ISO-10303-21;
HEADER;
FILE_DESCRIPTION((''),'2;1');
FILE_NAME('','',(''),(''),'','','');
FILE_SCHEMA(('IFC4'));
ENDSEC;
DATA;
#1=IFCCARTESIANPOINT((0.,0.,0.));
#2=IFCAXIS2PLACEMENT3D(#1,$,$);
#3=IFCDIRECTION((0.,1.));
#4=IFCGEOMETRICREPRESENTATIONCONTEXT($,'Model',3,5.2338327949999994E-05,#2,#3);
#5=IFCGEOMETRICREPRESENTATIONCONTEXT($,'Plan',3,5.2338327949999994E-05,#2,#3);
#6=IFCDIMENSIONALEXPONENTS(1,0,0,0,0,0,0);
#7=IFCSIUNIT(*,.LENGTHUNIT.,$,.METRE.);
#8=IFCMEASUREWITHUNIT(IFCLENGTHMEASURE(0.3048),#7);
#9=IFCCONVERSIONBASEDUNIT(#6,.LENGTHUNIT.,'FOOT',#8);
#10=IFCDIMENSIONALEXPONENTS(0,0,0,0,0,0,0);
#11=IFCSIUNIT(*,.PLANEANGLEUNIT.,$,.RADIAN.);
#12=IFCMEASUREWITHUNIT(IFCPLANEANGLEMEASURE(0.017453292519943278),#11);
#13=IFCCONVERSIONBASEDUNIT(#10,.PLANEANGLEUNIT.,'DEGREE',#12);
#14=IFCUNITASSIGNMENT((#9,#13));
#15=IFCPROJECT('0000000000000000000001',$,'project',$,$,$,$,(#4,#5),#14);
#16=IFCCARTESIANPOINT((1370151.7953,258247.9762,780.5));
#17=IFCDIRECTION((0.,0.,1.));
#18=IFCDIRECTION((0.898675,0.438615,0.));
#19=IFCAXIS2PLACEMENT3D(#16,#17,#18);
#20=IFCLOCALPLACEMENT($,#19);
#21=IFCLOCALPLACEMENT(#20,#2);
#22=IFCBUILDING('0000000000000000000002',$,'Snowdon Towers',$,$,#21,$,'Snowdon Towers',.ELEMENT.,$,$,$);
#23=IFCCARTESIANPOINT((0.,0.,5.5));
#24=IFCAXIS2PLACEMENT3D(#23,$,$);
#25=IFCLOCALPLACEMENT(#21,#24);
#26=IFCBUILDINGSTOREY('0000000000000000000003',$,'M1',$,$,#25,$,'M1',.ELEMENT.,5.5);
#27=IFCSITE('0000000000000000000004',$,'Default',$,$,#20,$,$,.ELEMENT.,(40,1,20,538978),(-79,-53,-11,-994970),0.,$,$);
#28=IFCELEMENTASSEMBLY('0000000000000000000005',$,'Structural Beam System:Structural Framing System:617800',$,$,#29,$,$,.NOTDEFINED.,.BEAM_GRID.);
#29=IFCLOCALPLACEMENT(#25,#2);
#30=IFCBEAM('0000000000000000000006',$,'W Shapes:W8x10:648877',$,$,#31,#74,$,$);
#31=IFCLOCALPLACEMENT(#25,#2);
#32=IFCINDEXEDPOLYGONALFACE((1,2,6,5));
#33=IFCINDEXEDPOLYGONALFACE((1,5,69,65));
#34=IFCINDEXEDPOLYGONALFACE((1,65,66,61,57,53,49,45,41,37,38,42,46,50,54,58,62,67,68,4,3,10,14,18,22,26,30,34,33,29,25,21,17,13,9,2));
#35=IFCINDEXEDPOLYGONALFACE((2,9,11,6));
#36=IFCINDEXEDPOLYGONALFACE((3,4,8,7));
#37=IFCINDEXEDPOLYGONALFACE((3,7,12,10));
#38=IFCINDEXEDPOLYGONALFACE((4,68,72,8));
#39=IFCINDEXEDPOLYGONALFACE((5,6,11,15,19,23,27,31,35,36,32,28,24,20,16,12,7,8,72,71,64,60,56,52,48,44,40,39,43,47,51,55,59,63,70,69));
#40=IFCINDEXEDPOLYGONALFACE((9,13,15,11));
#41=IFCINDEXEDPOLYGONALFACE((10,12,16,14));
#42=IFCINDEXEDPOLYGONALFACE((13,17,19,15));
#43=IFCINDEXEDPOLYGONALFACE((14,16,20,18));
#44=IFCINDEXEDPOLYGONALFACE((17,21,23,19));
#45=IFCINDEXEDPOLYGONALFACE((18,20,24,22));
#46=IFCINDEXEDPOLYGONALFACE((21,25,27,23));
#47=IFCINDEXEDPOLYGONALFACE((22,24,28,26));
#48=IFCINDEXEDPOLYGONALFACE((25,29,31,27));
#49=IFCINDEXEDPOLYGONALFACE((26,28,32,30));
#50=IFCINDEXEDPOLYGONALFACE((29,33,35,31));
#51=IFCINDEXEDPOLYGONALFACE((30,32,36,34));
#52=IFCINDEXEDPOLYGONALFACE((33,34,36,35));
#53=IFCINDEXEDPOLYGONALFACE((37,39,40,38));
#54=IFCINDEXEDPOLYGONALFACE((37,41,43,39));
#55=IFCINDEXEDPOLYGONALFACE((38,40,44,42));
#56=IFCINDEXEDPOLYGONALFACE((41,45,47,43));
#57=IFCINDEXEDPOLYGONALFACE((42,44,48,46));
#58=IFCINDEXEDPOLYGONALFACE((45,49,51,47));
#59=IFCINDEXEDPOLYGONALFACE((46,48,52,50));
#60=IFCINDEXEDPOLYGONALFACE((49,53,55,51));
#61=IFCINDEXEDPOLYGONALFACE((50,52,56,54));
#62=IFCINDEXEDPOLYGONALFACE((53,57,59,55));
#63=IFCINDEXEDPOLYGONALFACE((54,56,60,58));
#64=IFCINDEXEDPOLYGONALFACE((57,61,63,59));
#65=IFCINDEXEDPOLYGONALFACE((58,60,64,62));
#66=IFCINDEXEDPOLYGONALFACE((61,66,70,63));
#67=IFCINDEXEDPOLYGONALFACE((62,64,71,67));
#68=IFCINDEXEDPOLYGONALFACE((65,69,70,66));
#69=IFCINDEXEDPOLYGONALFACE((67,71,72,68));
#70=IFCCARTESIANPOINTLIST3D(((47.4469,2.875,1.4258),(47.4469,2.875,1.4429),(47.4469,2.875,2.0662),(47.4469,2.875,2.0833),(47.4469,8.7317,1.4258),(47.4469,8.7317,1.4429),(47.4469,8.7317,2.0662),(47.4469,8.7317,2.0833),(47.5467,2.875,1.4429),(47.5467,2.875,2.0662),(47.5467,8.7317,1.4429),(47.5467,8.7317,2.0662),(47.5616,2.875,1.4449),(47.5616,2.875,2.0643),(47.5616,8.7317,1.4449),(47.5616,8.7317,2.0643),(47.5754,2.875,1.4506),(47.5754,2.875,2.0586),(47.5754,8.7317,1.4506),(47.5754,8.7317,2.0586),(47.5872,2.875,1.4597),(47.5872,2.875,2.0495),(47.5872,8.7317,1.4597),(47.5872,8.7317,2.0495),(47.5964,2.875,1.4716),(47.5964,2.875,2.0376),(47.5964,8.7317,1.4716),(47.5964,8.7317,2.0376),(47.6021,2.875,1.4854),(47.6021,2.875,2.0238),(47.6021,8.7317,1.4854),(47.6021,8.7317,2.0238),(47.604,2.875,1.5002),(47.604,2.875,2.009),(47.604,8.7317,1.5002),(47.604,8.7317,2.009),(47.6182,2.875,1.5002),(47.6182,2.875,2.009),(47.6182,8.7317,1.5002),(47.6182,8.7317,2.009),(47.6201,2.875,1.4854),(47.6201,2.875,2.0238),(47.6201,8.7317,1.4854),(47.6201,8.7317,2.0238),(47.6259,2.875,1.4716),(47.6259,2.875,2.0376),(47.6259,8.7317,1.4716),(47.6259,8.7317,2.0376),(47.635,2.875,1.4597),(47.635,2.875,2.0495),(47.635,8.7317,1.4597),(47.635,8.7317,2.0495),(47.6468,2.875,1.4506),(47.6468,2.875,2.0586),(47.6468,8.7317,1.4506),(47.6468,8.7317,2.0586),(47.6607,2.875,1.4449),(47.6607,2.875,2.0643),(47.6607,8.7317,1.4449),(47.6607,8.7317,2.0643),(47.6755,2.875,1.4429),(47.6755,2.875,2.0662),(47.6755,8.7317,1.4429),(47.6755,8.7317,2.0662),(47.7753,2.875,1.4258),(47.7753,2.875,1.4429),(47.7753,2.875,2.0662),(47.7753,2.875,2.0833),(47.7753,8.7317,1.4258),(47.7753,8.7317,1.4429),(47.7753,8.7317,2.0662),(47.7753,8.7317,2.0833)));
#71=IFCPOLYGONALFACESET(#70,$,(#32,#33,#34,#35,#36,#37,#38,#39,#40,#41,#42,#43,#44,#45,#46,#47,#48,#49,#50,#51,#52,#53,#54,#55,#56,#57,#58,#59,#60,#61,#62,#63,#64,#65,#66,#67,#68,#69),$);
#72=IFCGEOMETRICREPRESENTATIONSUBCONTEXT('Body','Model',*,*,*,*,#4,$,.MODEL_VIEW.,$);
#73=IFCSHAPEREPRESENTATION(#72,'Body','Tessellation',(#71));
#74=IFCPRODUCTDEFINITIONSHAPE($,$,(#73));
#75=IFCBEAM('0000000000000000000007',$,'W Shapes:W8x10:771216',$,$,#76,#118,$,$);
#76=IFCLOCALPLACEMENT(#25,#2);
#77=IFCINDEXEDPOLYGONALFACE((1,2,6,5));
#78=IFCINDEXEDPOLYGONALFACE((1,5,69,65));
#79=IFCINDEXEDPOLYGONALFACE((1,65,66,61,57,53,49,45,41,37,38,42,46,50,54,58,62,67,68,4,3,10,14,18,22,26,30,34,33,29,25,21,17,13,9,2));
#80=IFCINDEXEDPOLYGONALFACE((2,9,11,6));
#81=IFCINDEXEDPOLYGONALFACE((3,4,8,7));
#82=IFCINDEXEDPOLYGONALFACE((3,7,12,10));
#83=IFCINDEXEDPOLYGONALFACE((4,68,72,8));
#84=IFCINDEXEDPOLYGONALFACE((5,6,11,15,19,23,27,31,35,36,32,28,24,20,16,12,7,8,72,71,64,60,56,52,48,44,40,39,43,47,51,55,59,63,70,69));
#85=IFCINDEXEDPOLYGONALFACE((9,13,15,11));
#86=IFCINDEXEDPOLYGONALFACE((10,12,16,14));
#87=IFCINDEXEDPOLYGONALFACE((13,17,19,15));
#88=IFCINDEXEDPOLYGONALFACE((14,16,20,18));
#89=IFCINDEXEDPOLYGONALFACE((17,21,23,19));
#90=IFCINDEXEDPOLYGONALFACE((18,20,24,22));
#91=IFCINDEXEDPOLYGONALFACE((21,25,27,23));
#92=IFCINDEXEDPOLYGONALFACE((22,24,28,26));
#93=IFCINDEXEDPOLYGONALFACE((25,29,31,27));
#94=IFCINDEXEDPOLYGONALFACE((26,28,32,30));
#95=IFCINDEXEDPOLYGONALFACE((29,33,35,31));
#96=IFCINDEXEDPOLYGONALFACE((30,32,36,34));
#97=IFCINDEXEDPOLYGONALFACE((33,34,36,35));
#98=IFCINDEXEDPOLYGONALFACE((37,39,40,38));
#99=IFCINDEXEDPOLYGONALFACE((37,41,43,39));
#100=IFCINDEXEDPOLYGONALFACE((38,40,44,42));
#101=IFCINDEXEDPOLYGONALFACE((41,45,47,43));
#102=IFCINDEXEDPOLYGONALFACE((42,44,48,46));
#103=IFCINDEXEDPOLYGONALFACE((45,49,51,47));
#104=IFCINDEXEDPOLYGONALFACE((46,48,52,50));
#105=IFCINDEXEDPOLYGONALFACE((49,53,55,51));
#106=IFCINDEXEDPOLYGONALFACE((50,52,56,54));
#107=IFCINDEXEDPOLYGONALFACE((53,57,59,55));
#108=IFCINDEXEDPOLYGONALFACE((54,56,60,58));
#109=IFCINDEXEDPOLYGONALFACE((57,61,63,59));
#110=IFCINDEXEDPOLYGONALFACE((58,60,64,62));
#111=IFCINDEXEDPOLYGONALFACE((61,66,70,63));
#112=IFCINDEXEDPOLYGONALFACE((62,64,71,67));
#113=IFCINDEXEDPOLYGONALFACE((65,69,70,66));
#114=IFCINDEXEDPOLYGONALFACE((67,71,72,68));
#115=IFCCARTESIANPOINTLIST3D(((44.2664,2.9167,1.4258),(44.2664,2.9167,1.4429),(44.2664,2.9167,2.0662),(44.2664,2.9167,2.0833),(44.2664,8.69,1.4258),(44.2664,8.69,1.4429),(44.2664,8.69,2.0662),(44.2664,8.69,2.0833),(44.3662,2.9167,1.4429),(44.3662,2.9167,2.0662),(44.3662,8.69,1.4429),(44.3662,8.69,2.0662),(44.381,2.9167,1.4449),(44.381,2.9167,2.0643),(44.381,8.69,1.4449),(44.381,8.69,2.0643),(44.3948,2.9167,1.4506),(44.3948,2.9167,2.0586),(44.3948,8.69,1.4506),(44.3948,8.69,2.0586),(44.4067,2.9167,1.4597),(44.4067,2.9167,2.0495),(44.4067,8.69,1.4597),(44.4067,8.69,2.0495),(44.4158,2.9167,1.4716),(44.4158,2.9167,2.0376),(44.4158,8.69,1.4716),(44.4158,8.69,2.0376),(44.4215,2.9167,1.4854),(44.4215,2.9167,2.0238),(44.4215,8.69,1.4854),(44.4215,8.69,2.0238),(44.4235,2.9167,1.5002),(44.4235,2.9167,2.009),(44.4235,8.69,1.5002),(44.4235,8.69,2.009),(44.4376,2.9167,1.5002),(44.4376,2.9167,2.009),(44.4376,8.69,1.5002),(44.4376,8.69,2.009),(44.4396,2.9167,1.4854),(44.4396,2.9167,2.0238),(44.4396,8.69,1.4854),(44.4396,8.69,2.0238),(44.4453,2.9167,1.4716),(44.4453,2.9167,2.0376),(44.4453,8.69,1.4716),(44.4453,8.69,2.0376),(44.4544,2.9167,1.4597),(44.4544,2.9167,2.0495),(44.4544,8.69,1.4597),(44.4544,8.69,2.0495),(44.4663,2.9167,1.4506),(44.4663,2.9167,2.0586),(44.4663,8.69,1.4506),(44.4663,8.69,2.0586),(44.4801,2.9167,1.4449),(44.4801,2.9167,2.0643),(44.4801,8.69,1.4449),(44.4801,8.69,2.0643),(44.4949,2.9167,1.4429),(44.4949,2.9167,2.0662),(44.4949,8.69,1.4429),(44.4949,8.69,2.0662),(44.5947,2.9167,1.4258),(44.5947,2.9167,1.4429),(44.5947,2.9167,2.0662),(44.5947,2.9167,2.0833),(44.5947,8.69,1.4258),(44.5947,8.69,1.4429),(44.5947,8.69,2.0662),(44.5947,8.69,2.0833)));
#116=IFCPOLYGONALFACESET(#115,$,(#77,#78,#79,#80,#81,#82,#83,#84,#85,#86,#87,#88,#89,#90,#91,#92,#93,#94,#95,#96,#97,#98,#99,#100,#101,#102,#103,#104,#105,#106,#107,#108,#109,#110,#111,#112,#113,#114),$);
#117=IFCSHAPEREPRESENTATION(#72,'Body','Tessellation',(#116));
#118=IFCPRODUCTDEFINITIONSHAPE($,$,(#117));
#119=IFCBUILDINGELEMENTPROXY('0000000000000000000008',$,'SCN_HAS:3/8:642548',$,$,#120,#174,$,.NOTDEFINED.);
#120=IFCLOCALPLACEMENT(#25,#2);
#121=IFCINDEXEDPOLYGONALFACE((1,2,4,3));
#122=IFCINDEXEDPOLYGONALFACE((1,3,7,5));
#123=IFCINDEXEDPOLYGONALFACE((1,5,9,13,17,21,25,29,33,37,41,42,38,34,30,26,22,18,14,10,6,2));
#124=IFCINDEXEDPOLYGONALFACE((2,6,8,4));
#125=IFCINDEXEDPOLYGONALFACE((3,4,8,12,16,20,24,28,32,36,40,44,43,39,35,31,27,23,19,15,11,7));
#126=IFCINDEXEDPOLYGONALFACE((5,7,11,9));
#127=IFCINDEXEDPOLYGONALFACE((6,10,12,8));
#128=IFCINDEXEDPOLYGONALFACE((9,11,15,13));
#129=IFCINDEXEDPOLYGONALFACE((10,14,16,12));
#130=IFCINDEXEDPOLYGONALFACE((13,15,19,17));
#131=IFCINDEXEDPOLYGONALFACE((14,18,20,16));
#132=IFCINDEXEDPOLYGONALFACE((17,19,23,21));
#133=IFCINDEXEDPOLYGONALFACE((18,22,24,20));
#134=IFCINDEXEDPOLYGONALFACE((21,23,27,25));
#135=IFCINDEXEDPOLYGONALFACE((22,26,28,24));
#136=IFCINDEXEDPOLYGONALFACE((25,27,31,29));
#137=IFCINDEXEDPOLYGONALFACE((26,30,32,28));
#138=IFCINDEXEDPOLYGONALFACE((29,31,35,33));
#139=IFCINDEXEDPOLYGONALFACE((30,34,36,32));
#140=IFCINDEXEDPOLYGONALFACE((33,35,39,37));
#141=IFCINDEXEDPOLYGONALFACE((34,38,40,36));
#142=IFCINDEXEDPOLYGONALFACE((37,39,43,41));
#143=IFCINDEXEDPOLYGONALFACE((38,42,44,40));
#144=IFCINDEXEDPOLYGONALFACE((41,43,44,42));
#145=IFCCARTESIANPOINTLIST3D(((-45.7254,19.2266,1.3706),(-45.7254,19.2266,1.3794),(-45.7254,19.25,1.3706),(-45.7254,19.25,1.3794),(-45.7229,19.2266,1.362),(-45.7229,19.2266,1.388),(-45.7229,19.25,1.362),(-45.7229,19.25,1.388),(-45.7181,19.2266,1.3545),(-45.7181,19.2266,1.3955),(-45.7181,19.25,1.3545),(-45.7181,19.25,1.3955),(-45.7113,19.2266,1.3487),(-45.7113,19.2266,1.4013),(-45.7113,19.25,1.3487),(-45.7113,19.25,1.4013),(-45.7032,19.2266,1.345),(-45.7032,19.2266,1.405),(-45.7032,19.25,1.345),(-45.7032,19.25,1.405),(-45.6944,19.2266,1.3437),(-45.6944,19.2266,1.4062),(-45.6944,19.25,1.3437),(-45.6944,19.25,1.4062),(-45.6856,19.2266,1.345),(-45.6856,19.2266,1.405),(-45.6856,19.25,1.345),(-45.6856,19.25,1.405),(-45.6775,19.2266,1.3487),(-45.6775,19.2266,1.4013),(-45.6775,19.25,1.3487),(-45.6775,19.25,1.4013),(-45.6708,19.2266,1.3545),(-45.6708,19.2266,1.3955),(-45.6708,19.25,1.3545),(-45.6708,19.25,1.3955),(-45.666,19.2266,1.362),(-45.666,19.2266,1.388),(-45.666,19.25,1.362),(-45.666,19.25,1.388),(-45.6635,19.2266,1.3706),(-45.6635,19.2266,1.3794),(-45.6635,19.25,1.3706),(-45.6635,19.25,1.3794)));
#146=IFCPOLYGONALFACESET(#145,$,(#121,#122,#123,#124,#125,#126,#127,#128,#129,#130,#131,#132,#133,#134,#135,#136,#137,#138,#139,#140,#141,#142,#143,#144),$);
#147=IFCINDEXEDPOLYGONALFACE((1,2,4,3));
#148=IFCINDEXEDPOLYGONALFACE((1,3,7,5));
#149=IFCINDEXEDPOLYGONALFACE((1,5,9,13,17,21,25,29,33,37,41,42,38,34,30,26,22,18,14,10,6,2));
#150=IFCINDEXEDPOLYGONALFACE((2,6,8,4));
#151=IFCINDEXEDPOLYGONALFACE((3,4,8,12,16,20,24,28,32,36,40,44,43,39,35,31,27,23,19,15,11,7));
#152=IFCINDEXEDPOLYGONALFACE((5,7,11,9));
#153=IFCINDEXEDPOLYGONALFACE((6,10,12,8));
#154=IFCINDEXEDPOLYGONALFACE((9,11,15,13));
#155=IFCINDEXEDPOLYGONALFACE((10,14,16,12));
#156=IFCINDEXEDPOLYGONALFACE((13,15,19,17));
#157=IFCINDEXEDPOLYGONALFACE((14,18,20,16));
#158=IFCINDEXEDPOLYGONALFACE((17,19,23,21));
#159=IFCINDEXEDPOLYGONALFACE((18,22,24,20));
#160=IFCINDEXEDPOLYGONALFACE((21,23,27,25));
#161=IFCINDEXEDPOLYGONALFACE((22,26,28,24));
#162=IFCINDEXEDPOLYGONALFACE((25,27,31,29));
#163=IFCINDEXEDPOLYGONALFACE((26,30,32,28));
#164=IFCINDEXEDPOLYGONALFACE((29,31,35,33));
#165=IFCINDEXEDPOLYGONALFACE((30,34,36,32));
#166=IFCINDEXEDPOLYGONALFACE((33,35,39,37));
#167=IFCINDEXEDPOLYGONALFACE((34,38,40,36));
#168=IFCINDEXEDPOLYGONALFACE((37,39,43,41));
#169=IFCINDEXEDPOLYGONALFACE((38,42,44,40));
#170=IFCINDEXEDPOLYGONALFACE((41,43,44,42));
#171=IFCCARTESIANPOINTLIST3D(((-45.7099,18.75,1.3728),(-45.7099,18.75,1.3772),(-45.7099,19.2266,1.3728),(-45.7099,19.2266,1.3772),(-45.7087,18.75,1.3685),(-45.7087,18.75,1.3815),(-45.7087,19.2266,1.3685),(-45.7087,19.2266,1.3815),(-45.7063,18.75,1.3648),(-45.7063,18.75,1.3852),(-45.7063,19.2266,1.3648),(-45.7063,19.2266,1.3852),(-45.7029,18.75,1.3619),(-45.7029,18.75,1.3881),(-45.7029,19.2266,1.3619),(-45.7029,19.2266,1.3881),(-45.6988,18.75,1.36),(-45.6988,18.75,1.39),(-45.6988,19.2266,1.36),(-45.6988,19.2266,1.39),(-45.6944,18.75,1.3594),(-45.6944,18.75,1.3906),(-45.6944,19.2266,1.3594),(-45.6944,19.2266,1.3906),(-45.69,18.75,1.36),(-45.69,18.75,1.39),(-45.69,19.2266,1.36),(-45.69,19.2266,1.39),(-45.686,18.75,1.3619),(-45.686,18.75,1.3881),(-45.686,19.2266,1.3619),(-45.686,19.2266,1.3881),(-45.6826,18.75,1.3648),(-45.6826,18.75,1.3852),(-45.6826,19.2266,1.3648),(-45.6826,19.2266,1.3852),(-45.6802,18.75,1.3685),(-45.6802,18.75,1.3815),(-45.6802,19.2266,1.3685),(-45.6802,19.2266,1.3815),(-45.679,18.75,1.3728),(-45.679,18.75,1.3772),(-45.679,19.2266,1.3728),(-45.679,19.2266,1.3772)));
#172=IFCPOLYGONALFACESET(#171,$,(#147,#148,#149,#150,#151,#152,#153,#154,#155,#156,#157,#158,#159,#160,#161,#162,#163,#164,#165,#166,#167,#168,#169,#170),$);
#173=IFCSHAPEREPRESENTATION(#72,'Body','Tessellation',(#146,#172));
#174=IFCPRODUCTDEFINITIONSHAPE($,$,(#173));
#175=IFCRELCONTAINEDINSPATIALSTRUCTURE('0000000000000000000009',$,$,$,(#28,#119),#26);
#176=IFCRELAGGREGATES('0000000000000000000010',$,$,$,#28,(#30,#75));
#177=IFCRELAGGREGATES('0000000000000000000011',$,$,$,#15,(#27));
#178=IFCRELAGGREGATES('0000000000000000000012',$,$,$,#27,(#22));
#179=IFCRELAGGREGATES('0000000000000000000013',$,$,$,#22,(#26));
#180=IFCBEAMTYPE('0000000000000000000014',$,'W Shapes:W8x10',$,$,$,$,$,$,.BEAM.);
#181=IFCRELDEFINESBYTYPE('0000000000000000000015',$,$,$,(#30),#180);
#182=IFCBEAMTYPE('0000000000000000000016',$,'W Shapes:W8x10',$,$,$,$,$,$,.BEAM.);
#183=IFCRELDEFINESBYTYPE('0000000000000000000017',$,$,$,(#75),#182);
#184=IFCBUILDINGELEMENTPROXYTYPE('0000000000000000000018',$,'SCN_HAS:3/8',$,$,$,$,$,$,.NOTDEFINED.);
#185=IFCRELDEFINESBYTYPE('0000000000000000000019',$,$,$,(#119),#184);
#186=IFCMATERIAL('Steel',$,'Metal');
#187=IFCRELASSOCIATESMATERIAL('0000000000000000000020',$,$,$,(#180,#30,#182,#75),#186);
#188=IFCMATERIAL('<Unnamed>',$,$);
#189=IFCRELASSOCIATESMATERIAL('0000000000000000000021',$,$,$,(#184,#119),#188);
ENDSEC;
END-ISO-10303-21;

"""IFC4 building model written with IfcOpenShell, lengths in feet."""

from ifc_helpers import new_model, entity, si_unit, converted_unit, direction, frame, origin, place, context, subcontext, project, spatial, line, arc, indexed_curve, outline, extrude, source, transform, mapped, material, type_object, type_shapes, element, aggregate, save


model = new_model("IFC4")

# Units and contexts
model_context = context("Model", 3, precision=5.2338327949999994e-05, world=origin(), true_north=direction((0.0, 1.0)))
plan_context = context("Plan", 3, precision=5.2338327949999994e-05, world=origin(), true_north=direction((0.0, 1.0)))
body_context = subcontext(model_context, "Body", "Model", "MODEL_VIEW")
ifc_project = project(units=[converted_unit("LENGTHUNIT", "FOOT", entity("IfcLengthMeasure", 0.3048), si_unit("LENGTHUNIT", "METRE"), dimensions=[1, 0, 0, 0, 0, 0, 0]), converted_unit("PLANEANGLEUNIT", "DEGREE", entity("IfcPlaneAngleMeasure", 0.017453292519943278), si_unit("PLANEANGLEUNIT", "RADIAN"), dimensions=[0, 0, 0, 0, 0, 0, 0])], contexts=[model_context, plan_context])

# Site, building, storey
site_placement = place(None, frame((1370151.7953, 258247.9762, 780.5), z_axis=(0.0, 0.0, 1.0), x_axis=(0.898675, 0.438615, 0.0)))
site = spatial("IfcSite", under=ifc_project, at=site_placement, Name="Default", CompositionType="ELEMENT", RefLatitude=(40, 1, 20, 538978), RefLongitude=(-79, -53, -11, -994970), RefElevation=0.0)
building_placement = place(site_placement, origin())
building = spatial("IfcBuilding", under=site, at=building_placement, Name="Snowdon Towers", LongName="Snowdon Towers", CompositionType="ELEMENT")
storey_placement = place(building_placement, frame((0.0, 0.0, 5.5)))
storey = spatial("IfcBuildingStorey", under=building, at=storey_placement, Name="M1", LongName="M1", CompositionType="ELEMENT", Elevation=5.5)

# Shared definitions
ifc_material_1 = material(Name="Steel", Category="Metal")

# Element assembly, beams
assembly_placement = place(storey_placement, origin())
assembly = element("IfcElementAssembly", 1, at=assembly_placement, inside=storey, Name="Structural Beam System:Structural Framing System:617800", AssemblyPlace="NOTDEFINED", PredefinedType="BEAM_GRID")
beam_type_1 = type_object("IfcBeamType", Name="W Shapes:W8x10", PredefinedType="BEAM", material=ifc_material_1)
shared_shape_1 = source(origin(), body_context, "Body", "SweptSolid", [
    extrude(outline(indexed_curve([(-0.3287, -0.1642), (-0.3117, -0.1642), (-0.3117, -0.0644), (-0.2949, -0.0239), (-0.2544, -0.0071), (0.2544, -0.0071), (0.2949, -0.0239), (0.3117, -0.0644), (0.3117, -0.1642), (0.3288, -0.1642), (0.3288, 0.1642), (0.3117, 0.1642), (0.3117, 0.0644), (0.2949, 0.0239), (0.2544, 0.0071), (-0.2544, 0.0071), (-0.2949, 0.0239), (-0.3117, 0.0644), (-0.3117, 0.1642), (-0.3287, 0.1642)], segments=[line(1, 2, 3), arc(3, 4, 5), line(5, 6), arc(6, 7, 8), line(8, 9, 10, 11, 12, 13), arc(13, 14, 15), line(15, 16), arc(16, 17, 18), line(18, 19, 20, 1)], self_intersect=False)), frame((-3.0962, 0.0, 0.0), z_axis=(1.0, 0.0, 0.0), x_axis=(0.0, 0.0, -1.0)), (0.0, 0.0, 1.0), 5.8567),
])
type_shapes(beam_type_1, [shared_shape_1])
beam_1_placement = place(assembly_placement, frame((47.6111, 5.6354, 1.7546), z_axis=(0.0, 0.0, 1.0), x_axis=(0.0, -1.0, 0.0)))
beam_1 = element("IfcBeam", 2, at=beam_1_placement, type_object=beam_type_1, material=ifc_material_1, Name="W Shapes:W8x10:648877", context=body_context, shape_type="MappedRepresentation", body=[
    mapped(shared_shape_1, transform((0.0, 0.0, 0.0), scale=1.0)),
])
beam_type_2 = type_object("IfcBeamType", Name="W Shapes:W8x10", PredefinedType="BEAM", material=ifc_material_1)
shared_shape_2 = source(origin(), body_context, "Body", "SweptSolid", [
    extrude(outline(indexed_curve([(-0.3287, -0.1642), (-0.3117, -0.1642), (-0.3117, -0.0644), (-0.2949, -0.0239), (-0.2544, -0.0071), (0.2544, -0.0071), (0.2949, -0.0239), (0.3117, -0.0644), (0.3117, -0.1642), (0.3288, -0.1642), (0.3288, 0.1642), (0.3117, 0.1642), (0.3117, 0.0644), (0.2949, 0.0239), (0.2544, 0.0071), (-0.2544, 0.0071), (-0.2949, 0.0239), (-0.3117, 0.0644), (-0.3117, 0.1642), (-0.3287, 0.1642)], segments=[line(1, 2, 3), arc(3, 4, 5), line(5, 6), arc(6, 7, 8), line(8, 9, 10, 11, 12, 13), arc(13, 14, 15), line(15, 16), arc(16, 17, 18), line(18, 19, 20, 1)], self_intersect=False)), frame((-3.0546, 0.0, 0.0), z_axis=(1.0, 0.0, 0.0), x_axis=(0.0, 0.0, -1.0)), (0.0, 0.0, 1.0), 5.7733),
])
type_shapes(beam_type_2, [shared_shape_2])
beam_2_placement = place(assembly_placement, frame((44.4306, 5.6354, 1.7546), z_axis=(0.0, 0.0, 1.0), x_axis=(0.0, -1.0, 0.0)))
beam_2 = element("IfcBeam", 3, at=beam_2_placement, type_object=beam_type_2, material=ifc_material_1, Name="W Shapes:W8x10:771216", context=body_context, shape_type="MappedRepresentation", body=[
    mapped(shared_shape_2, transform((0.0, 0.0, 0.0), scale=1.0)),
])
aggregate(assembly, [beam_1, beam_2])

# Building element proxy
ifc_material_2 = material(Name="<Unnamed>")
building_element_proxy_type = type_object("IfcBuildingElementProxyType", Name="SCN_HAS:3/8", PredefinedType="NOTDEFINED", material=ifc_material_2)
shared_shape_3 = source(origin(), body_context, "Body", "SweptSolid", [
    extrude(outline(indexed_curve([(-0.0312, 0.0), (0.0, -0.0313), (0.0312, 0.0), (0.0, 0.0312)], segments=[arc(1, 2, 3), arc(3, 4, 1)], self_intersect=False)), frame((0.0, 0.0, -0.5), z_axis=(0.0, 0.0, 1.0), x_axis=(0.0, -1.0, 0.0)), (0.0, 0.0, 1.0), 0.0234),
    extrude(outline(indexed_curve([(-0.0156, 0.0), (0.0, -0.0156), (0.0156, 0.0), (0.0, 0.0156)], segments=[arc(1, 2, 3), arc(3, 4, 1)], self_intersect=False)), frame((0.0, 0.0, -0.4766), z_axis=(0.0, 0.0, 1.0), x_axis=(0.0, -1.0, 0.0)), (0.0, 0.0, 1.0), 0.4766),
])
type_shapes(building_element_proxy_type, [shared_shape_3])
for number, where, z_axis, x_axis, name in (
    (4, (-45.6944, 18.75, 1.375), (0.0, -1.0, 0.0), (1.0, 0.0, 0.0), "SCN_HAS:3/8:642548"),
):
    element("IfcBuildingElementProxy", number, at=place(storey_placement, frame(where, z_axis=z_axis, x_axis=x_axis)), inside=storey, type_object=building_element_proxy_type, material=ifc_material_2, Name=name, PredefinedType="NOTDEFINED", context=body_context, shape_type="MappedRepresentation", body=[
        mapped(shared_shape_3, transform((0.0, 0.0, 0.0), scale=1.0)),
    ])

save(model, "model.ifc")
